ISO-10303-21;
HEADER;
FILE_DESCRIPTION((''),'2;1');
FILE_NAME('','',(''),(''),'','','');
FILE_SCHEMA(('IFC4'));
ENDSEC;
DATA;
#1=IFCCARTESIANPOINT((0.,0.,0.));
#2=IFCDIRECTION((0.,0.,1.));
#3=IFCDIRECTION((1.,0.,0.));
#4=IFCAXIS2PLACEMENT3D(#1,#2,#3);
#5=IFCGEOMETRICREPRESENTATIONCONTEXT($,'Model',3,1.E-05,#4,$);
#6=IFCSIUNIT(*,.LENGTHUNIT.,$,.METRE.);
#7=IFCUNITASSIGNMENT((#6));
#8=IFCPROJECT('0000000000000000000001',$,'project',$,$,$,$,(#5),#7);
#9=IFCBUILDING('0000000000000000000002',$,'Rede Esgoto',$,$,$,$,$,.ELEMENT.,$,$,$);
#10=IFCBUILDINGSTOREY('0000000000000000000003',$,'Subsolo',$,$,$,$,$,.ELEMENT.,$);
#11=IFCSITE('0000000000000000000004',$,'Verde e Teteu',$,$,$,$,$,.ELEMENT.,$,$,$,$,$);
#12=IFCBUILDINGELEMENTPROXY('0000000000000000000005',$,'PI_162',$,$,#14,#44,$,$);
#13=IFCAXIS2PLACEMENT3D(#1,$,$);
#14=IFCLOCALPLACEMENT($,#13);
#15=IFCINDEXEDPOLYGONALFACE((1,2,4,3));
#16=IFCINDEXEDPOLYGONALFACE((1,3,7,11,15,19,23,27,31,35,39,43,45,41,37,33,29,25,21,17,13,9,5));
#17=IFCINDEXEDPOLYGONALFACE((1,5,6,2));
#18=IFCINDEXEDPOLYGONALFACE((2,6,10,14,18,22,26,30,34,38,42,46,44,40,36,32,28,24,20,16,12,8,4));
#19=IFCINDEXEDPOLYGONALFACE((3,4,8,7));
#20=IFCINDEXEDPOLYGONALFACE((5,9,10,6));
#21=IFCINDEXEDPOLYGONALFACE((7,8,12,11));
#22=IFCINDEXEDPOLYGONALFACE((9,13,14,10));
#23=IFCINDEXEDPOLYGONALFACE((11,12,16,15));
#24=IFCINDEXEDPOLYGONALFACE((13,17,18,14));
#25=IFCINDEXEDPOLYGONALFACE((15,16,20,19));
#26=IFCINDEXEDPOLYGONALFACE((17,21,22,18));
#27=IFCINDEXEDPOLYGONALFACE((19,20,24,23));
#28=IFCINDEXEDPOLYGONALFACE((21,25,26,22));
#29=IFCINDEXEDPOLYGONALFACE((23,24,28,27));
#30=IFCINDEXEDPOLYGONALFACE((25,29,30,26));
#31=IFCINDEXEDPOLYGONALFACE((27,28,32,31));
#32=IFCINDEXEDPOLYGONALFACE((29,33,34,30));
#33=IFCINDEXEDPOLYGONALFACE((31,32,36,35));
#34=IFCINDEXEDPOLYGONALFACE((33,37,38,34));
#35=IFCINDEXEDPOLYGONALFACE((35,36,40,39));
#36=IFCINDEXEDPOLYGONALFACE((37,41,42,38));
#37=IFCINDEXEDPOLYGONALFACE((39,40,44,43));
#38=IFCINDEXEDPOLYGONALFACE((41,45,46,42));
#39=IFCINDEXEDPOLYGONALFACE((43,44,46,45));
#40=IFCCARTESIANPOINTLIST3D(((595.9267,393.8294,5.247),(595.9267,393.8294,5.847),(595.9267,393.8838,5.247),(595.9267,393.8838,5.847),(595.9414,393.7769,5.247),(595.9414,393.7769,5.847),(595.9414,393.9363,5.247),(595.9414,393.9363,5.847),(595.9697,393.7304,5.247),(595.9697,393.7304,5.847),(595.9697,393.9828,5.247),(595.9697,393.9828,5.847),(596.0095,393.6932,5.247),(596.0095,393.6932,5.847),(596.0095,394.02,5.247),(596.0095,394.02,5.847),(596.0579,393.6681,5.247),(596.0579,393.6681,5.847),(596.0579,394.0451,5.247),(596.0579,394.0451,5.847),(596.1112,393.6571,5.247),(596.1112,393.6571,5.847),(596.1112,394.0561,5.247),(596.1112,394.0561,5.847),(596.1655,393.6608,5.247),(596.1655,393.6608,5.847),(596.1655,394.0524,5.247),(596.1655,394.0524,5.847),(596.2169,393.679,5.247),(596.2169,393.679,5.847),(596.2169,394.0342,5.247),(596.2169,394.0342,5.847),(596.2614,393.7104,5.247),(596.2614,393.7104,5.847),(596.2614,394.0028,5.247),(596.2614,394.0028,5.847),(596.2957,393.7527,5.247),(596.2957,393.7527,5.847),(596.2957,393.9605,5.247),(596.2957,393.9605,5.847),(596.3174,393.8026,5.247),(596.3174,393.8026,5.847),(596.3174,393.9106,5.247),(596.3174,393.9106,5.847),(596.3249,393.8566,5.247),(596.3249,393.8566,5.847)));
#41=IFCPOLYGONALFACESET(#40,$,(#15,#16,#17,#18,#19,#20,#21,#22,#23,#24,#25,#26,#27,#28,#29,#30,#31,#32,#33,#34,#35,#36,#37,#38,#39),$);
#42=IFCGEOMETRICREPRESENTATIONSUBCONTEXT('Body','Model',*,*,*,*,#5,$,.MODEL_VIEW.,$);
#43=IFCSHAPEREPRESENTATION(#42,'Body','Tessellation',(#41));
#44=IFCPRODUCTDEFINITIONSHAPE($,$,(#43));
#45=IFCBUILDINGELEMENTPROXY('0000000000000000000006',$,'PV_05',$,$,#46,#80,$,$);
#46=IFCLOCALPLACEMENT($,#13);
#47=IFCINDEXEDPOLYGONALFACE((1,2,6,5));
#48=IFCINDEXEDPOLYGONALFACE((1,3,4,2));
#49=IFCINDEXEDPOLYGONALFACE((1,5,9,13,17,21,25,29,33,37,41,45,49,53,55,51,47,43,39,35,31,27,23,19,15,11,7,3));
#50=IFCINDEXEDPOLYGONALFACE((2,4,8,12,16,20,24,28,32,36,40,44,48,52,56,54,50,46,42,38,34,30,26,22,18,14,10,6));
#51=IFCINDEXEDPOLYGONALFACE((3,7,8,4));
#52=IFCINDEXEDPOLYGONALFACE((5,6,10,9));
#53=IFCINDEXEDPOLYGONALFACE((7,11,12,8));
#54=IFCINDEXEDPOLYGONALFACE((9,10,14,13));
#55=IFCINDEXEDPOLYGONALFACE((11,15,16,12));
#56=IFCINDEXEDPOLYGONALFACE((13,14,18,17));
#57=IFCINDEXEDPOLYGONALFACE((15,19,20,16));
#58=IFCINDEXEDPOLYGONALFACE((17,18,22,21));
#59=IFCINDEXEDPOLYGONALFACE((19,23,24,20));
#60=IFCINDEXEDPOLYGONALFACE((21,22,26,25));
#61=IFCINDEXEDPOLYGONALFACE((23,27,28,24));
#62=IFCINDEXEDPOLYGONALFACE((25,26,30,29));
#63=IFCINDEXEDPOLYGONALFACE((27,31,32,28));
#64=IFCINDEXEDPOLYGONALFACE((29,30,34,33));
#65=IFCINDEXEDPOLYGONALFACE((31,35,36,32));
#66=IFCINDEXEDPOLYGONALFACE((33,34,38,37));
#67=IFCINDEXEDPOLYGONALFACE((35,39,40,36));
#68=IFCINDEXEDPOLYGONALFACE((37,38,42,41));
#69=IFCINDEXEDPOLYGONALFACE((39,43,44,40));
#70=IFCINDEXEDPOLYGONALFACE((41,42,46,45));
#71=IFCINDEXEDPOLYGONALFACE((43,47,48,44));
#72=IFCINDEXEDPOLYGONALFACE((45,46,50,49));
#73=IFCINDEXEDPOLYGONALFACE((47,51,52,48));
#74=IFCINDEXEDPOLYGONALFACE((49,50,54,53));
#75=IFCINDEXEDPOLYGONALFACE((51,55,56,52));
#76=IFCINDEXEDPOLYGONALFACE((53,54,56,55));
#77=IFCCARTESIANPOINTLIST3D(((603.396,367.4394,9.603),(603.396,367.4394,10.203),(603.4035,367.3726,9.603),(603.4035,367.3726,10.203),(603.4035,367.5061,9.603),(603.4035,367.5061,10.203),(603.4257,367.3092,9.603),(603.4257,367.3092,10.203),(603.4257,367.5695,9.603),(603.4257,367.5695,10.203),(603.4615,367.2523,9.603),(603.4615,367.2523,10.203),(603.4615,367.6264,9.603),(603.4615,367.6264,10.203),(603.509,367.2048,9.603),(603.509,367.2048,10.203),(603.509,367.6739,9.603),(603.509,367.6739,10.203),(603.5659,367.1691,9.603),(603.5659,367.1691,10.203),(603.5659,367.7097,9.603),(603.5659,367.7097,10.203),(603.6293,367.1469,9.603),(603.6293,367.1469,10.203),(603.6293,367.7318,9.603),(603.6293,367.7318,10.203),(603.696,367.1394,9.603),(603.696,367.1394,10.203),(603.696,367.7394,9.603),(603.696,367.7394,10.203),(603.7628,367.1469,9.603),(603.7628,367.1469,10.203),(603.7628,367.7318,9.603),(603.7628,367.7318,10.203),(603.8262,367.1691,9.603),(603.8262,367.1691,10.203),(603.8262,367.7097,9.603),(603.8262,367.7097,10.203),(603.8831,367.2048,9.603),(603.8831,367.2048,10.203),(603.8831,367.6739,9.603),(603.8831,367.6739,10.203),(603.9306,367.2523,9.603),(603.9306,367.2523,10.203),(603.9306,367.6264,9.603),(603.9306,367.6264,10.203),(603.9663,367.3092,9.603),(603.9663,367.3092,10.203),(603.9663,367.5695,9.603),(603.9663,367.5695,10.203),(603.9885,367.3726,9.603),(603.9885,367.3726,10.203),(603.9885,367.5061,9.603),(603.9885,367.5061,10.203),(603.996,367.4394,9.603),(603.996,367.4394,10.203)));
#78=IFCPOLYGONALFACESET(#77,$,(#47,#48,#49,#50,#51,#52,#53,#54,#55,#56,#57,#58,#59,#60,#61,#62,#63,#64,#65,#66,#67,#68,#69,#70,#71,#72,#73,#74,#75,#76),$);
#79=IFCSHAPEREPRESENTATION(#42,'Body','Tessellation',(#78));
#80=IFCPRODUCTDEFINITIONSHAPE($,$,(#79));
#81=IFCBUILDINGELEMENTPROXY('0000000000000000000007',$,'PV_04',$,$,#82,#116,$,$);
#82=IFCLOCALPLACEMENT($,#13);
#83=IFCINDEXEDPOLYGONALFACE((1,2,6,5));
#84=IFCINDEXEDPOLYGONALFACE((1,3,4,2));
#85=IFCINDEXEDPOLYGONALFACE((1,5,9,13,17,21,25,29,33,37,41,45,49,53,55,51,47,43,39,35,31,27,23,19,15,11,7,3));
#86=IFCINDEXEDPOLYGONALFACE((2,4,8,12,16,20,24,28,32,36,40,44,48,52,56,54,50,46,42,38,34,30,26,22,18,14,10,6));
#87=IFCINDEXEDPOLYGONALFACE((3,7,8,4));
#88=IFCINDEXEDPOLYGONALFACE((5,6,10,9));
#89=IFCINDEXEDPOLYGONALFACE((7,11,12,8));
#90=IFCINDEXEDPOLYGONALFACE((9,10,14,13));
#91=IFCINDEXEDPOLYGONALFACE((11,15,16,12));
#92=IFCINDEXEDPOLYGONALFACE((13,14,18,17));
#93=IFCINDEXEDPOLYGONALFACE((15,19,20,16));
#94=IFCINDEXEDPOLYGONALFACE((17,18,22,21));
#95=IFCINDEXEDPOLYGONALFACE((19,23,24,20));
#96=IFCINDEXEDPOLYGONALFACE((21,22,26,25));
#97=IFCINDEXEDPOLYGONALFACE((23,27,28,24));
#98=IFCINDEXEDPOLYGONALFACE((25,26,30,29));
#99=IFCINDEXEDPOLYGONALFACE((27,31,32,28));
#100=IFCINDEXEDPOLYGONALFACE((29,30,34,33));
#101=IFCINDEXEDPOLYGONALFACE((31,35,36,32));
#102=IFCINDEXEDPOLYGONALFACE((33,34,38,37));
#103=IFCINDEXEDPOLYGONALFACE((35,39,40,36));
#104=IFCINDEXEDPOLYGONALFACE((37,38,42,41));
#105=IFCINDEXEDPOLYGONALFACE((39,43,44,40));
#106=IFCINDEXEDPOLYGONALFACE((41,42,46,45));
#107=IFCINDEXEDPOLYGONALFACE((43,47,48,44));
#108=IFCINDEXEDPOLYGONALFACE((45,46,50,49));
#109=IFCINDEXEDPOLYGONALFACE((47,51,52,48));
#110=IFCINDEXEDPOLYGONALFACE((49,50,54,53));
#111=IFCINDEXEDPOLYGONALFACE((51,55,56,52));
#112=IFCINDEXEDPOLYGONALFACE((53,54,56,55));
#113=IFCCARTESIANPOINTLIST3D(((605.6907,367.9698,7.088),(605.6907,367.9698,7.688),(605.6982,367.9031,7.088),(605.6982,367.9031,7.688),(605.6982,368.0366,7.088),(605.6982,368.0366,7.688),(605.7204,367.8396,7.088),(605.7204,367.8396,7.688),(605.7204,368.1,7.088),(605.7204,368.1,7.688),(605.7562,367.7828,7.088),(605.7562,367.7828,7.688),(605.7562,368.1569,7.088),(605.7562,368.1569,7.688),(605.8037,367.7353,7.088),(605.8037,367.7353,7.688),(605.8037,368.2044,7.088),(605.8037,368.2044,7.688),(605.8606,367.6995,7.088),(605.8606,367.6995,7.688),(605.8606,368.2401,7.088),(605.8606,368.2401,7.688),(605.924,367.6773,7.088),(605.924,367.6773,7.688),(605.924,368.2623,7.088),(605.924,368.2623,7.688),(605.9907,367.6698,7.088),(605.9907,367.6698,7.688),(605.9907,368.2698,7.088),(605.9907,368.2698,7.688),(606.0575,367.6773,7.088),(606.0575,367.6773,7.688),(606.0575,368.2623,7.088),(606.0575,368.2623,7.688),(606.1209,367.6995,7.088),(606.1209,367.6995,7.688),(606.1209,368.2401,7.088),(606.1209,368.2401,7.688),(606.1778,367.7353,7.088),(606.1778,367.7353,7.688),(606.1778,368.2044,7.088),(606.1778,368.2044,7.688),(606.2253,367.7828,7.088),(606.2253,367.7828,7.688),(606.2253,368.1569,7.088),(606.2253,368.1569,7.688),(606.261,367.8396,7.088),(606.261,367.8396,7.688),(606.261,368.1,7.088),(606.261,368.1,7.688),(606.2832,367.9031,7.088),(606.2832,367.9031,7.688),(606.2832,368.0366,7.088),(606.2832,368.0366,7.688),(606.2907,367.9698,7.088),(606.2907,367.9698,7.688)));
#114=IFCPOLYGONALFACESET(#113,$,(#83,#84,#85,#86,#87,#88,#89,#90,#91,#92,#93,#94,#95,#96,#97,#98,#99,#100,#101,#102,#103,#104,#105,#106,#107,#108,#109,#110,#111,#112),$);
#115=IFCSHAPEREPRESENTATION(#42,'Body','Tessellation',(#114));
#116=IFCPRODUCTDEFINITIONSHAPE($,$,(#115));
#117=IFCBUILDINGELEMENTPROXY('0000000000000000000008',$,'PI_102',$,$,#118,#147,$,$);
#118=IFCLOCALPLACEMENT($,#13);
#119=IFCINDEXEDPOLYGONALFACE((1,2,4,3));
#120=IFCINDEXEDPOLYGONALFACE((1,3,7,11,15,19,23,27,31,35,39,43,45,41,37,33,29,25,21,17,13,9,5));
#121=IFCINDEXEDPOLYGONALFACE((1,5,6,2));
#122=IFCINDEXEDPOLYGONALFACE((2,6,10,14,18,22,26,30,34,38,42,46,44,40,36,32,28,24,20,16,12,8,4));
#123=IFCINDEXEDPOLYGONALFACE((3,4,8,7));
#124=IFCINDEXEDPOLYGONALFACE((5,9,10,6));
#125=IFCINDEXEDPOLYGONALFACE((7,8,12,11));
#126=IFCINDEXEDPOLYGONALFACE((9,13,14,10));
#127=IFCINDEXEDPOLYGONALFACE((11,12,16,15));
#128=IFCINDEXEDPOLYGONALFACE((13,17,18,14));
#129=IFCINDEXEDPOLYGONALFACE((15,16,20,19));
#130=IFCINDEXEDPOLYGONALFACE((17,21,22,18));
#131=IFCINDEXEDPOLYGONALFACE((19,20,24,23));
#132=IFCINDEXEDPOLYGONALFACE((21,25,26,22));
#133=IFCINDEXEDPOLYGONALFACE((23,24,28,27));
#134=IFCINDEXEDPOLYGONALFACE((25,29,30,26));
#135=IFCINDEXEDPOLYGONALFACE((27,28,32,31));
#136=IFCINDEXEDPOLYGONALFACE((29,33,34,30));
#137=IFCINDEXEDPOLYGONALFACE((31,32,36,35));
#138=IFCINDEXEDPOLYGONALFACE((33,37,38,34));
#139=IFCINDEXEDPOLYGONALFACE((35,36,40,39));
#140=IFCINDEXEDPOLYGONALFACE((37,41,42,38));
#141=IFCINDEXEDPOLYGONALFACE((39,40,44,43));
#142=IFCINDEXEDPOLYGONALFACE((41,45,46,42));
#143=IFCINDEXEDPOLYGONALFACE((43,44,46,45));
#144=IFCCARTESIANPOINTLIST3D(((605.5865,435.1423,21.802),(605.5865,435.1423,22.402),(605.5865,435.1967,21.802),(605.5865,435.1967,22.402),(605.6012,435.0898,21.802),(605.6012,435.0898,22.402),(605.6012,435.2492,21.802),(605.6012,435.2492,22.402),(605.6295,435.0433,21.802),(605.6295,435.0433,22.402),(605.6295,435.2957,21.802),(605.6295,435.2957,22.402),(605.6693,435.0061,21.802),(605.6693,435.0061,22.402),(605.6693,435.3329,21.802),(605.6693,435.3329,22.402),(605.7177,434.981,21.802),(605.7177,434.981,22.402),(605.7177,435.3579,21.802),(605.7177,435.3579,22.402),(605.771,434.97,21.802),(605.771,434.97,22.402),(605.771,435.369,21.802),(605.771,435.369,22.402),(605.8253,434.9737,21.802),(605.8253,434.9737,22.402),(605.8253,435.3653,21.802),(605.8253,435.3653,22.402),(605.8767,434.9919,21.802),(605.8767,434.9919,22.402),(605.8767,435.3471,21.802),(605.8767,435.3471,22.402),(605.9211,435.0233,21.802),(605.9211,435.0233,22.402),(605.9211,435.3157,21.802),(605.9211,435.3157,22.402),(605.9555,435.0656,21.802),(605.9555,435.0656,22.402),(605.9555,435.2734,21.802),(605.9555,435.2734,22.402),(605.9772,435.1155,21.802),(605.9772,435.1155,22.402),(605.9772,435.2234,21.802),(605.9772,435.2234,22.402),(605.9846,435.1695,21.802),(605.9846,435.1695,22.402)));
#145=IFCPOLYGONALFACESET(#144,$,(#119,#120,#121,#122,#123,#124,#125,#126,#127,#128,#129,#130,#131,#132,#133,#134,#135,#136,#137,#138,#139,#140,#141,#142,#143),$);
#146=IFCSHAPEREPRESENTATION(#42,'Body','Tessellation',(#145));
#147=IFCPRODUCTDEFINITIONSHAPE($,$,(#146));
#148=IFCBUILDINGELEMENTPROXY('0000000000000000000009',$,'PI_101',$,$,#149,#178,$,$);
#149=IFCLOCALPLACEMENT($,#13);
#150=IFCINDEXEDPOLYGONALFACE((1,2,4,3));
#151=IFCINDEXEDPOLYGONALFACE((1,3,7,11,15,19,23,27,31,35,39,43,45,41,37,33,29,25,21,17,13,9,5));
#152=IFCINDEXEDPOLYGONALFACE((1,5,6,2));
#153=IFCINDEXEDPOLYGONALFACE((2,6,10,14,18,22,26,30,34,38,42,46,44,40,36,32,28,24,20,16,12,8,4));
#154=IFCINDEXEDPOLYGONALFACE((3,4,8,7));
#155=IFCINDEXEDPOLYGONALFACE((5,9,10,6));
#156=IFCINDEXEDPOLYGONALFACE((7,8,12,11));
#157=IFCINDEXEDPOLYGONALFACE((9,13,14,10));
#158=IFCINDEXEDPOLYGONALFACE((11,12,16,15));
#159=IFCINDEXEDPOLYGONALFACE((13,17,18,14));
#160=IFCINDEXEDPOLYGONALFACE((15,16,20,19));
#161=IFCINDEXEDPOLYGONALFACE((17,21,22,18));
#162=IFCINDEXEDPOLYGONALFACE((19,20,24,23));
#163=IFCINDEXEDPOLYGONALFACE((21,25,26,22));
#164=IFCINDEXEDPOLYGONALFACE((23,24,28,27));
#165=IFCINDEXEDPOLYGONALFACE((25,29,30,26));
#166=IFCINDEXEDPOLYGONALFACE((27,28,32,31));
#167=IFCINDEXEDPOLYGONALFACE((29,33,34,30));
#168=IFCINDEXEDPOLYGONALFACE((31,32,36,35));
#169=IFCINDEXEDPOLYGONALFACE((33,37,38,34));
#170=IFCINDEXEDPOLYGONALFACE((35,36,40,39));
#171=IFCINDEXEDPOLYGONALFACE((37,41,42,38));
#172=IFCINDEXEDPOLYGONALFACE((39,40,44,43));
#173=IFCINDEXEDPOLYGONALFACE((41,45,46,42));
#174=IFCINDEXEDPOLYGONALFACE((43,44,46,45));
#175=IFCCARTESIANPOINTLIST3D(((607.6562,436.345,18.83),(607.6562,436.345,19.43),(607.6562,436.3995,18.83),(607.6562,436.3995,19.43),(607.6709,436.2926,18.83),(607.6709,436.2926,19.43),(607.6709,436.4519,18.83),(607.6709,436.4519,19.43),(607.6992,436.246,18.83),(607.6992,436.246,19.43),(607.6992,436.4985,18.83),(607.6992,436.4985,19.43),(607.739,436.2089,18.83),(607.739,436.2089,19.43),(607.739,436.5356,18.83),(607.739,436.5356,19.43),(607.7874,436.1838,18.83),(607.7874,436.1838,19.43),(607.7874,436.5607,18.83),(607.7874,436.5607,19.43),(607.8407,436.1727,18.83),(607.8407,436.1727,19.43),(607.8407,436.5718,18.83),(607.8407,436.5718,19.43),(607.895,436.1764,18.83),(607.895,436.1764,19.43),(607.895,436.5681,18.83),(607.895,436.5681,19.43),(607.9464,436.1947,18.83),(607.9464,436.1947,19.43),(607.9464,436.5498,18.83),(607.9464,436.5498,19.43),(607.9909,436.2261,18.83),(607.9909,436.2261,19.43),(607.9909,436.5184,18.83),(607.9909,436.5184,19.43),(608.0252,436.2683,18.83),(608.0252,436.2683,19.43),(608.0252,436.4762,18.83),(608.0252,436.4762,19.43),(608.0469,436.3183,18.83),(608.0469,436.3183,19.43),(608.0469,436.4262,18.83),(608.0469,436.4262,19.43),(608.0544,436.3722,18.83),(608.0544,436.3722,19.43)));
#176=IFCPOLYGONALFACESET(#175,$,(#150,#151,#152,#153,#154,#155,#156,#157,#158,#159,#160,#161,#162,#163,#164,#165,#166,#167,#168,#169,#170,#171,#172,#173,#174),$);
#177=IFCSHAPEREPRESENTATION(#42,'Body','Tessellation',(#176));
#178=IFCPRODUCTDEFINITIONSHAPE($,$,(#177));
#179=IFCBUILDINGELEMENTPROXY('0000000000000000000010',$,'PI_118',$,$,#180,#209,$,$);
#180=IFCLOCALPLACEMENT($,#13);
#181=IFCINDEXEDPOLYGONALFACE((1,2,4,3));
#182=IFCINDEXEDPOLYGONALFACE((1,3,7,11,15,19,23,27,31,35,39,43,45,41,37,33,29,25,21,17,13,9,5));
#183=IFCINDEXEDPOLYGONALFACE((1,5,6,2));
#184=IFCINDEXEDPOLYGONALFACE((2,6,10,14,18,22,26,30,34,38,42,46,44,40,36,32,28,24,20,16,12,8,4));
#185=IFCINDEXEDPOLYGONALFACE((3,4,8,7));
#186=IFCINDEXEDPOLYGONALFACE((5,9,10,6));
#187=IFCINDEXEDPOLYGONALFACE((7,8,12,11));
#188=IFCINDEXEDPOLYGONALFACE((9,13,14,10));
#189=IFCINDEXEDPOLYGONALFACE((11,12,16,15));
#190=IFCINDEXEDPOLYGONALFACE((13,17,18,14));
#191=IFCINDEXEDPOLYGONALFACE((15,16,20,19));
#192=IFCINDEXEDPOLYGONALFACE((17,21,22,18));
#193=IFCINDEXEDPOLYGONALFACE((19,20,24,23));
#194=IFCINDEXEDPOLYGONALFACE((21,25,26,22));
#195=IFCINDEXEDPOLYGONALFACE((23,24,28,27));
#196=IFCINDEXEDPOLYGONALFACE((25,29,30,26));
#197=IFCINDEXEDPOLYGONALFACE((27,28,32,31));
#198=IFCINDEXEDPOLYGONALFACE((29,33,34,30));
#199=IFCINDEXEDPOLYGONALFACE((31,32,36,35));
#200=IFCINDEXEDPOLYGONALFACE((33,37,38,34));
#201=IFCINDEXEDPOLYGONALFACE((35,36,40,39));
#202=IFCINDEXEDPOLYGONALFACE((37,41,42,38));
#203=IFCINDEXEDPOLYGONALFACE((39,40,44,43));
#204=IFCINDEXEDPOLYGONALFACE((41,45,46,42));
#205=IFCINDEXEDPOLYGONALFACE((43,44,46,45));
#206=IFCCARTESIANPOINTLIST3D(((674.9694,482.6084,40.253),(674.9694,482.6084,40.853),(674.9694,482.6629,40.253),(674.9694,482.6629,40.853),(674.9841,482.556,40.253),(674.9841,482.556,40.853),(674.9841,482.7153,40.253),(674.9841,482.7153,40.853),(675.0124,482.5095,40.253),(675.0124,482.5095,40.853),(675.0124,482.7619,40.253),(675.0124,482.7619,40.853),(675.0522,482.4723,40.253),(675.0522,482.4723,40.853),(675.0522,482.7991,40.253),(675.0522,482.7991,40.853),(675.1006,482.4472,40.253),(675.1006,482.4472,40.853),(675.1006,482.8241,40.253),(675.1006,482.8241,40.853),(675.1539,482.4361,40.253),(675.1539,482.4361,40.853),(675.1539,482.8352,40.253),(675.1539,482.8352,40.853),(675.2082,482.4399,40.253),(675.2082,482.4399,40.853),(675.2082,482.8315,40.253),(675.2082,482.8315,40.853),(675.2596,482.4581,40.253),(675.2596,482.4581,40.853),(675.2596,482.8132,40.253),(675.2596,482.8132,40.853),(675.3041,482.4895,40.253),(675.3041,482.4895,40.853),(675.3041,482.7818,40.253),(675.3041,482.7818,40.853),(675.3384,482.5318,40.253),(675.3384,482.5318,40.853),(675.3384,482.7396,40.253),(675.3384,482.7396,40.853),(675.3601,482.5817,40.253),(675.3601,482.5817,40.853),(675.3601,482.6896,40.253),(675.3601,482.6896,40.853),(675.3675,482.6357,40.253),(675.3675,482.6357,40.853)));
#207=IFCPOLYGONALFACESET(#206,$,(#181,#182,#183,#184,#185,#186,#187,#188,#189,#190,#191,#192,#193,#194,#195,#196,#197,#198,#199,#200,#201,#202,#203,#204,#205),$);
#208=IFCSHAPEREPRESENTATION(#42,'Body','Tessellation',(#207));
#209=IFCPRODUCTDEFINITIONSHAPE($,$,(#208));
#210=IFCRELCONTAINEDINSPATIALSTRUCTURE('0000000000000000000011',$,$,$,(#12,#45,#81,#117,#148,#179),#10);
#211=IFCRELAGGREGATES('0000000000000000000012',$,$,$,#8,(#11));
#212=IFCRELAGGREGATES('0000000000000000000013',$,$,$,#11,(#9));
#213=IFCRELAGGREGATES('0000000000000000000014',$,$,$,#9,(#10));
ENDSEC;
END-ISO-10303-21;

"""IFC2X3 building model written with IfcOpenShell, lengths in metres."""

from ifc_helpers import new_model, si_unit, frame, origin_with_axes, origin_2d, place, context, subcontext, project, spatial, circle, extrude, element, save


model = new_model("IFC2X3")

# Units and contexts
model_context = context("Model", 3, precision=1e-05, world=origin_with_axes())
body_context = subcontext(model_context, "Body", "Model", "MODEL_VIEW")
ifc_project = project(units=[si_unit("LENGTHUNIT", "METRE")], contexts=[model_context])

# Site, building, storey
site = spatial("IfcSite", under=ifc_project, Name="Verde e Teteu", CompositionType="ELEMENT")
building = spatial("IfcBuilding", under=site, Name="Rede Esgoto", CompositionType="ELEMENT")
storey = spatial("IfcBuildingStorey", under=building, Name="Subsolo", CompositionType="ELEMENT")

# Building element proxies
proxy_1_placement = place(None, frame((596.1249, 393.8566, 5.247), z_axis=(0.0, 0.0, 1.0), x_axis=(1.0, 0.0, 0.0)))
element("IfcBuildingElementProxy", 1, at=proxy_1_placement, inside=storey, Name="PI_162", context=body_context, shape_type="SweptSolid", body=[
    extrude(circle(Radius=0.2, at=origin_2d()), origin_with_axes(), (0.0, 0.0, 1.0), 0.6),
])
for number, where, z_axis, x_axis, name in (
    (2, (603.696, 367.4394, 9.603), (0.0, 0.0, 1.0), (1.0, 0.0, 0.0), "PV_05"),
    (3, (605.9907, 367.9698, 7.088), (0.0, 0.0, 1.0), (1.0, 0.0, 0.0), "PV_04"),
):
    element("IfcBuildingElementProxy", number, at=place(None, frame(where, z_axis=z_axis, x_axis=x_axis)), inside=storey, Name=name, context=body_context, shape_type="SweptSolid", body=[
        extrude(circle(Radius=0.3, at=origin_2d()), origin_with_axes(), (0.0, 0.0, 1.0), 0.6),
    ])
for number, where, z_axis, x_axis, name in (
    (4, (605.7846, 435.1695, 21.802), (0.0, 0.0, 1.0), (1.0, 0.0, 0.0), "PI_102"),
    (5, (607.8544, 436.3722, 18.83), (0.0, 0.0, 1.0), (1.0, 0.0, 0.0), "PI_101"),
    (6, (675.1675, 482.6357, 40.253), (0.0, 0.0, 1.0), (1.0, 0.0, 0.0), "PI_118"),
):
    element("IfcBuildingElementProxy", number, at=place(None, frame(where, z_axis=z_axis, x_axis=x_axis)), inside=storey, Name=name, context=body_context, shape_type="SweptSolid", body=[
        extrude(circle(Radius=0.2, at=origin_2d()), origin_with_axes(), (0.0, 0.0, 1.0), 0.6),
    ])

save(model, "model.ifc")
